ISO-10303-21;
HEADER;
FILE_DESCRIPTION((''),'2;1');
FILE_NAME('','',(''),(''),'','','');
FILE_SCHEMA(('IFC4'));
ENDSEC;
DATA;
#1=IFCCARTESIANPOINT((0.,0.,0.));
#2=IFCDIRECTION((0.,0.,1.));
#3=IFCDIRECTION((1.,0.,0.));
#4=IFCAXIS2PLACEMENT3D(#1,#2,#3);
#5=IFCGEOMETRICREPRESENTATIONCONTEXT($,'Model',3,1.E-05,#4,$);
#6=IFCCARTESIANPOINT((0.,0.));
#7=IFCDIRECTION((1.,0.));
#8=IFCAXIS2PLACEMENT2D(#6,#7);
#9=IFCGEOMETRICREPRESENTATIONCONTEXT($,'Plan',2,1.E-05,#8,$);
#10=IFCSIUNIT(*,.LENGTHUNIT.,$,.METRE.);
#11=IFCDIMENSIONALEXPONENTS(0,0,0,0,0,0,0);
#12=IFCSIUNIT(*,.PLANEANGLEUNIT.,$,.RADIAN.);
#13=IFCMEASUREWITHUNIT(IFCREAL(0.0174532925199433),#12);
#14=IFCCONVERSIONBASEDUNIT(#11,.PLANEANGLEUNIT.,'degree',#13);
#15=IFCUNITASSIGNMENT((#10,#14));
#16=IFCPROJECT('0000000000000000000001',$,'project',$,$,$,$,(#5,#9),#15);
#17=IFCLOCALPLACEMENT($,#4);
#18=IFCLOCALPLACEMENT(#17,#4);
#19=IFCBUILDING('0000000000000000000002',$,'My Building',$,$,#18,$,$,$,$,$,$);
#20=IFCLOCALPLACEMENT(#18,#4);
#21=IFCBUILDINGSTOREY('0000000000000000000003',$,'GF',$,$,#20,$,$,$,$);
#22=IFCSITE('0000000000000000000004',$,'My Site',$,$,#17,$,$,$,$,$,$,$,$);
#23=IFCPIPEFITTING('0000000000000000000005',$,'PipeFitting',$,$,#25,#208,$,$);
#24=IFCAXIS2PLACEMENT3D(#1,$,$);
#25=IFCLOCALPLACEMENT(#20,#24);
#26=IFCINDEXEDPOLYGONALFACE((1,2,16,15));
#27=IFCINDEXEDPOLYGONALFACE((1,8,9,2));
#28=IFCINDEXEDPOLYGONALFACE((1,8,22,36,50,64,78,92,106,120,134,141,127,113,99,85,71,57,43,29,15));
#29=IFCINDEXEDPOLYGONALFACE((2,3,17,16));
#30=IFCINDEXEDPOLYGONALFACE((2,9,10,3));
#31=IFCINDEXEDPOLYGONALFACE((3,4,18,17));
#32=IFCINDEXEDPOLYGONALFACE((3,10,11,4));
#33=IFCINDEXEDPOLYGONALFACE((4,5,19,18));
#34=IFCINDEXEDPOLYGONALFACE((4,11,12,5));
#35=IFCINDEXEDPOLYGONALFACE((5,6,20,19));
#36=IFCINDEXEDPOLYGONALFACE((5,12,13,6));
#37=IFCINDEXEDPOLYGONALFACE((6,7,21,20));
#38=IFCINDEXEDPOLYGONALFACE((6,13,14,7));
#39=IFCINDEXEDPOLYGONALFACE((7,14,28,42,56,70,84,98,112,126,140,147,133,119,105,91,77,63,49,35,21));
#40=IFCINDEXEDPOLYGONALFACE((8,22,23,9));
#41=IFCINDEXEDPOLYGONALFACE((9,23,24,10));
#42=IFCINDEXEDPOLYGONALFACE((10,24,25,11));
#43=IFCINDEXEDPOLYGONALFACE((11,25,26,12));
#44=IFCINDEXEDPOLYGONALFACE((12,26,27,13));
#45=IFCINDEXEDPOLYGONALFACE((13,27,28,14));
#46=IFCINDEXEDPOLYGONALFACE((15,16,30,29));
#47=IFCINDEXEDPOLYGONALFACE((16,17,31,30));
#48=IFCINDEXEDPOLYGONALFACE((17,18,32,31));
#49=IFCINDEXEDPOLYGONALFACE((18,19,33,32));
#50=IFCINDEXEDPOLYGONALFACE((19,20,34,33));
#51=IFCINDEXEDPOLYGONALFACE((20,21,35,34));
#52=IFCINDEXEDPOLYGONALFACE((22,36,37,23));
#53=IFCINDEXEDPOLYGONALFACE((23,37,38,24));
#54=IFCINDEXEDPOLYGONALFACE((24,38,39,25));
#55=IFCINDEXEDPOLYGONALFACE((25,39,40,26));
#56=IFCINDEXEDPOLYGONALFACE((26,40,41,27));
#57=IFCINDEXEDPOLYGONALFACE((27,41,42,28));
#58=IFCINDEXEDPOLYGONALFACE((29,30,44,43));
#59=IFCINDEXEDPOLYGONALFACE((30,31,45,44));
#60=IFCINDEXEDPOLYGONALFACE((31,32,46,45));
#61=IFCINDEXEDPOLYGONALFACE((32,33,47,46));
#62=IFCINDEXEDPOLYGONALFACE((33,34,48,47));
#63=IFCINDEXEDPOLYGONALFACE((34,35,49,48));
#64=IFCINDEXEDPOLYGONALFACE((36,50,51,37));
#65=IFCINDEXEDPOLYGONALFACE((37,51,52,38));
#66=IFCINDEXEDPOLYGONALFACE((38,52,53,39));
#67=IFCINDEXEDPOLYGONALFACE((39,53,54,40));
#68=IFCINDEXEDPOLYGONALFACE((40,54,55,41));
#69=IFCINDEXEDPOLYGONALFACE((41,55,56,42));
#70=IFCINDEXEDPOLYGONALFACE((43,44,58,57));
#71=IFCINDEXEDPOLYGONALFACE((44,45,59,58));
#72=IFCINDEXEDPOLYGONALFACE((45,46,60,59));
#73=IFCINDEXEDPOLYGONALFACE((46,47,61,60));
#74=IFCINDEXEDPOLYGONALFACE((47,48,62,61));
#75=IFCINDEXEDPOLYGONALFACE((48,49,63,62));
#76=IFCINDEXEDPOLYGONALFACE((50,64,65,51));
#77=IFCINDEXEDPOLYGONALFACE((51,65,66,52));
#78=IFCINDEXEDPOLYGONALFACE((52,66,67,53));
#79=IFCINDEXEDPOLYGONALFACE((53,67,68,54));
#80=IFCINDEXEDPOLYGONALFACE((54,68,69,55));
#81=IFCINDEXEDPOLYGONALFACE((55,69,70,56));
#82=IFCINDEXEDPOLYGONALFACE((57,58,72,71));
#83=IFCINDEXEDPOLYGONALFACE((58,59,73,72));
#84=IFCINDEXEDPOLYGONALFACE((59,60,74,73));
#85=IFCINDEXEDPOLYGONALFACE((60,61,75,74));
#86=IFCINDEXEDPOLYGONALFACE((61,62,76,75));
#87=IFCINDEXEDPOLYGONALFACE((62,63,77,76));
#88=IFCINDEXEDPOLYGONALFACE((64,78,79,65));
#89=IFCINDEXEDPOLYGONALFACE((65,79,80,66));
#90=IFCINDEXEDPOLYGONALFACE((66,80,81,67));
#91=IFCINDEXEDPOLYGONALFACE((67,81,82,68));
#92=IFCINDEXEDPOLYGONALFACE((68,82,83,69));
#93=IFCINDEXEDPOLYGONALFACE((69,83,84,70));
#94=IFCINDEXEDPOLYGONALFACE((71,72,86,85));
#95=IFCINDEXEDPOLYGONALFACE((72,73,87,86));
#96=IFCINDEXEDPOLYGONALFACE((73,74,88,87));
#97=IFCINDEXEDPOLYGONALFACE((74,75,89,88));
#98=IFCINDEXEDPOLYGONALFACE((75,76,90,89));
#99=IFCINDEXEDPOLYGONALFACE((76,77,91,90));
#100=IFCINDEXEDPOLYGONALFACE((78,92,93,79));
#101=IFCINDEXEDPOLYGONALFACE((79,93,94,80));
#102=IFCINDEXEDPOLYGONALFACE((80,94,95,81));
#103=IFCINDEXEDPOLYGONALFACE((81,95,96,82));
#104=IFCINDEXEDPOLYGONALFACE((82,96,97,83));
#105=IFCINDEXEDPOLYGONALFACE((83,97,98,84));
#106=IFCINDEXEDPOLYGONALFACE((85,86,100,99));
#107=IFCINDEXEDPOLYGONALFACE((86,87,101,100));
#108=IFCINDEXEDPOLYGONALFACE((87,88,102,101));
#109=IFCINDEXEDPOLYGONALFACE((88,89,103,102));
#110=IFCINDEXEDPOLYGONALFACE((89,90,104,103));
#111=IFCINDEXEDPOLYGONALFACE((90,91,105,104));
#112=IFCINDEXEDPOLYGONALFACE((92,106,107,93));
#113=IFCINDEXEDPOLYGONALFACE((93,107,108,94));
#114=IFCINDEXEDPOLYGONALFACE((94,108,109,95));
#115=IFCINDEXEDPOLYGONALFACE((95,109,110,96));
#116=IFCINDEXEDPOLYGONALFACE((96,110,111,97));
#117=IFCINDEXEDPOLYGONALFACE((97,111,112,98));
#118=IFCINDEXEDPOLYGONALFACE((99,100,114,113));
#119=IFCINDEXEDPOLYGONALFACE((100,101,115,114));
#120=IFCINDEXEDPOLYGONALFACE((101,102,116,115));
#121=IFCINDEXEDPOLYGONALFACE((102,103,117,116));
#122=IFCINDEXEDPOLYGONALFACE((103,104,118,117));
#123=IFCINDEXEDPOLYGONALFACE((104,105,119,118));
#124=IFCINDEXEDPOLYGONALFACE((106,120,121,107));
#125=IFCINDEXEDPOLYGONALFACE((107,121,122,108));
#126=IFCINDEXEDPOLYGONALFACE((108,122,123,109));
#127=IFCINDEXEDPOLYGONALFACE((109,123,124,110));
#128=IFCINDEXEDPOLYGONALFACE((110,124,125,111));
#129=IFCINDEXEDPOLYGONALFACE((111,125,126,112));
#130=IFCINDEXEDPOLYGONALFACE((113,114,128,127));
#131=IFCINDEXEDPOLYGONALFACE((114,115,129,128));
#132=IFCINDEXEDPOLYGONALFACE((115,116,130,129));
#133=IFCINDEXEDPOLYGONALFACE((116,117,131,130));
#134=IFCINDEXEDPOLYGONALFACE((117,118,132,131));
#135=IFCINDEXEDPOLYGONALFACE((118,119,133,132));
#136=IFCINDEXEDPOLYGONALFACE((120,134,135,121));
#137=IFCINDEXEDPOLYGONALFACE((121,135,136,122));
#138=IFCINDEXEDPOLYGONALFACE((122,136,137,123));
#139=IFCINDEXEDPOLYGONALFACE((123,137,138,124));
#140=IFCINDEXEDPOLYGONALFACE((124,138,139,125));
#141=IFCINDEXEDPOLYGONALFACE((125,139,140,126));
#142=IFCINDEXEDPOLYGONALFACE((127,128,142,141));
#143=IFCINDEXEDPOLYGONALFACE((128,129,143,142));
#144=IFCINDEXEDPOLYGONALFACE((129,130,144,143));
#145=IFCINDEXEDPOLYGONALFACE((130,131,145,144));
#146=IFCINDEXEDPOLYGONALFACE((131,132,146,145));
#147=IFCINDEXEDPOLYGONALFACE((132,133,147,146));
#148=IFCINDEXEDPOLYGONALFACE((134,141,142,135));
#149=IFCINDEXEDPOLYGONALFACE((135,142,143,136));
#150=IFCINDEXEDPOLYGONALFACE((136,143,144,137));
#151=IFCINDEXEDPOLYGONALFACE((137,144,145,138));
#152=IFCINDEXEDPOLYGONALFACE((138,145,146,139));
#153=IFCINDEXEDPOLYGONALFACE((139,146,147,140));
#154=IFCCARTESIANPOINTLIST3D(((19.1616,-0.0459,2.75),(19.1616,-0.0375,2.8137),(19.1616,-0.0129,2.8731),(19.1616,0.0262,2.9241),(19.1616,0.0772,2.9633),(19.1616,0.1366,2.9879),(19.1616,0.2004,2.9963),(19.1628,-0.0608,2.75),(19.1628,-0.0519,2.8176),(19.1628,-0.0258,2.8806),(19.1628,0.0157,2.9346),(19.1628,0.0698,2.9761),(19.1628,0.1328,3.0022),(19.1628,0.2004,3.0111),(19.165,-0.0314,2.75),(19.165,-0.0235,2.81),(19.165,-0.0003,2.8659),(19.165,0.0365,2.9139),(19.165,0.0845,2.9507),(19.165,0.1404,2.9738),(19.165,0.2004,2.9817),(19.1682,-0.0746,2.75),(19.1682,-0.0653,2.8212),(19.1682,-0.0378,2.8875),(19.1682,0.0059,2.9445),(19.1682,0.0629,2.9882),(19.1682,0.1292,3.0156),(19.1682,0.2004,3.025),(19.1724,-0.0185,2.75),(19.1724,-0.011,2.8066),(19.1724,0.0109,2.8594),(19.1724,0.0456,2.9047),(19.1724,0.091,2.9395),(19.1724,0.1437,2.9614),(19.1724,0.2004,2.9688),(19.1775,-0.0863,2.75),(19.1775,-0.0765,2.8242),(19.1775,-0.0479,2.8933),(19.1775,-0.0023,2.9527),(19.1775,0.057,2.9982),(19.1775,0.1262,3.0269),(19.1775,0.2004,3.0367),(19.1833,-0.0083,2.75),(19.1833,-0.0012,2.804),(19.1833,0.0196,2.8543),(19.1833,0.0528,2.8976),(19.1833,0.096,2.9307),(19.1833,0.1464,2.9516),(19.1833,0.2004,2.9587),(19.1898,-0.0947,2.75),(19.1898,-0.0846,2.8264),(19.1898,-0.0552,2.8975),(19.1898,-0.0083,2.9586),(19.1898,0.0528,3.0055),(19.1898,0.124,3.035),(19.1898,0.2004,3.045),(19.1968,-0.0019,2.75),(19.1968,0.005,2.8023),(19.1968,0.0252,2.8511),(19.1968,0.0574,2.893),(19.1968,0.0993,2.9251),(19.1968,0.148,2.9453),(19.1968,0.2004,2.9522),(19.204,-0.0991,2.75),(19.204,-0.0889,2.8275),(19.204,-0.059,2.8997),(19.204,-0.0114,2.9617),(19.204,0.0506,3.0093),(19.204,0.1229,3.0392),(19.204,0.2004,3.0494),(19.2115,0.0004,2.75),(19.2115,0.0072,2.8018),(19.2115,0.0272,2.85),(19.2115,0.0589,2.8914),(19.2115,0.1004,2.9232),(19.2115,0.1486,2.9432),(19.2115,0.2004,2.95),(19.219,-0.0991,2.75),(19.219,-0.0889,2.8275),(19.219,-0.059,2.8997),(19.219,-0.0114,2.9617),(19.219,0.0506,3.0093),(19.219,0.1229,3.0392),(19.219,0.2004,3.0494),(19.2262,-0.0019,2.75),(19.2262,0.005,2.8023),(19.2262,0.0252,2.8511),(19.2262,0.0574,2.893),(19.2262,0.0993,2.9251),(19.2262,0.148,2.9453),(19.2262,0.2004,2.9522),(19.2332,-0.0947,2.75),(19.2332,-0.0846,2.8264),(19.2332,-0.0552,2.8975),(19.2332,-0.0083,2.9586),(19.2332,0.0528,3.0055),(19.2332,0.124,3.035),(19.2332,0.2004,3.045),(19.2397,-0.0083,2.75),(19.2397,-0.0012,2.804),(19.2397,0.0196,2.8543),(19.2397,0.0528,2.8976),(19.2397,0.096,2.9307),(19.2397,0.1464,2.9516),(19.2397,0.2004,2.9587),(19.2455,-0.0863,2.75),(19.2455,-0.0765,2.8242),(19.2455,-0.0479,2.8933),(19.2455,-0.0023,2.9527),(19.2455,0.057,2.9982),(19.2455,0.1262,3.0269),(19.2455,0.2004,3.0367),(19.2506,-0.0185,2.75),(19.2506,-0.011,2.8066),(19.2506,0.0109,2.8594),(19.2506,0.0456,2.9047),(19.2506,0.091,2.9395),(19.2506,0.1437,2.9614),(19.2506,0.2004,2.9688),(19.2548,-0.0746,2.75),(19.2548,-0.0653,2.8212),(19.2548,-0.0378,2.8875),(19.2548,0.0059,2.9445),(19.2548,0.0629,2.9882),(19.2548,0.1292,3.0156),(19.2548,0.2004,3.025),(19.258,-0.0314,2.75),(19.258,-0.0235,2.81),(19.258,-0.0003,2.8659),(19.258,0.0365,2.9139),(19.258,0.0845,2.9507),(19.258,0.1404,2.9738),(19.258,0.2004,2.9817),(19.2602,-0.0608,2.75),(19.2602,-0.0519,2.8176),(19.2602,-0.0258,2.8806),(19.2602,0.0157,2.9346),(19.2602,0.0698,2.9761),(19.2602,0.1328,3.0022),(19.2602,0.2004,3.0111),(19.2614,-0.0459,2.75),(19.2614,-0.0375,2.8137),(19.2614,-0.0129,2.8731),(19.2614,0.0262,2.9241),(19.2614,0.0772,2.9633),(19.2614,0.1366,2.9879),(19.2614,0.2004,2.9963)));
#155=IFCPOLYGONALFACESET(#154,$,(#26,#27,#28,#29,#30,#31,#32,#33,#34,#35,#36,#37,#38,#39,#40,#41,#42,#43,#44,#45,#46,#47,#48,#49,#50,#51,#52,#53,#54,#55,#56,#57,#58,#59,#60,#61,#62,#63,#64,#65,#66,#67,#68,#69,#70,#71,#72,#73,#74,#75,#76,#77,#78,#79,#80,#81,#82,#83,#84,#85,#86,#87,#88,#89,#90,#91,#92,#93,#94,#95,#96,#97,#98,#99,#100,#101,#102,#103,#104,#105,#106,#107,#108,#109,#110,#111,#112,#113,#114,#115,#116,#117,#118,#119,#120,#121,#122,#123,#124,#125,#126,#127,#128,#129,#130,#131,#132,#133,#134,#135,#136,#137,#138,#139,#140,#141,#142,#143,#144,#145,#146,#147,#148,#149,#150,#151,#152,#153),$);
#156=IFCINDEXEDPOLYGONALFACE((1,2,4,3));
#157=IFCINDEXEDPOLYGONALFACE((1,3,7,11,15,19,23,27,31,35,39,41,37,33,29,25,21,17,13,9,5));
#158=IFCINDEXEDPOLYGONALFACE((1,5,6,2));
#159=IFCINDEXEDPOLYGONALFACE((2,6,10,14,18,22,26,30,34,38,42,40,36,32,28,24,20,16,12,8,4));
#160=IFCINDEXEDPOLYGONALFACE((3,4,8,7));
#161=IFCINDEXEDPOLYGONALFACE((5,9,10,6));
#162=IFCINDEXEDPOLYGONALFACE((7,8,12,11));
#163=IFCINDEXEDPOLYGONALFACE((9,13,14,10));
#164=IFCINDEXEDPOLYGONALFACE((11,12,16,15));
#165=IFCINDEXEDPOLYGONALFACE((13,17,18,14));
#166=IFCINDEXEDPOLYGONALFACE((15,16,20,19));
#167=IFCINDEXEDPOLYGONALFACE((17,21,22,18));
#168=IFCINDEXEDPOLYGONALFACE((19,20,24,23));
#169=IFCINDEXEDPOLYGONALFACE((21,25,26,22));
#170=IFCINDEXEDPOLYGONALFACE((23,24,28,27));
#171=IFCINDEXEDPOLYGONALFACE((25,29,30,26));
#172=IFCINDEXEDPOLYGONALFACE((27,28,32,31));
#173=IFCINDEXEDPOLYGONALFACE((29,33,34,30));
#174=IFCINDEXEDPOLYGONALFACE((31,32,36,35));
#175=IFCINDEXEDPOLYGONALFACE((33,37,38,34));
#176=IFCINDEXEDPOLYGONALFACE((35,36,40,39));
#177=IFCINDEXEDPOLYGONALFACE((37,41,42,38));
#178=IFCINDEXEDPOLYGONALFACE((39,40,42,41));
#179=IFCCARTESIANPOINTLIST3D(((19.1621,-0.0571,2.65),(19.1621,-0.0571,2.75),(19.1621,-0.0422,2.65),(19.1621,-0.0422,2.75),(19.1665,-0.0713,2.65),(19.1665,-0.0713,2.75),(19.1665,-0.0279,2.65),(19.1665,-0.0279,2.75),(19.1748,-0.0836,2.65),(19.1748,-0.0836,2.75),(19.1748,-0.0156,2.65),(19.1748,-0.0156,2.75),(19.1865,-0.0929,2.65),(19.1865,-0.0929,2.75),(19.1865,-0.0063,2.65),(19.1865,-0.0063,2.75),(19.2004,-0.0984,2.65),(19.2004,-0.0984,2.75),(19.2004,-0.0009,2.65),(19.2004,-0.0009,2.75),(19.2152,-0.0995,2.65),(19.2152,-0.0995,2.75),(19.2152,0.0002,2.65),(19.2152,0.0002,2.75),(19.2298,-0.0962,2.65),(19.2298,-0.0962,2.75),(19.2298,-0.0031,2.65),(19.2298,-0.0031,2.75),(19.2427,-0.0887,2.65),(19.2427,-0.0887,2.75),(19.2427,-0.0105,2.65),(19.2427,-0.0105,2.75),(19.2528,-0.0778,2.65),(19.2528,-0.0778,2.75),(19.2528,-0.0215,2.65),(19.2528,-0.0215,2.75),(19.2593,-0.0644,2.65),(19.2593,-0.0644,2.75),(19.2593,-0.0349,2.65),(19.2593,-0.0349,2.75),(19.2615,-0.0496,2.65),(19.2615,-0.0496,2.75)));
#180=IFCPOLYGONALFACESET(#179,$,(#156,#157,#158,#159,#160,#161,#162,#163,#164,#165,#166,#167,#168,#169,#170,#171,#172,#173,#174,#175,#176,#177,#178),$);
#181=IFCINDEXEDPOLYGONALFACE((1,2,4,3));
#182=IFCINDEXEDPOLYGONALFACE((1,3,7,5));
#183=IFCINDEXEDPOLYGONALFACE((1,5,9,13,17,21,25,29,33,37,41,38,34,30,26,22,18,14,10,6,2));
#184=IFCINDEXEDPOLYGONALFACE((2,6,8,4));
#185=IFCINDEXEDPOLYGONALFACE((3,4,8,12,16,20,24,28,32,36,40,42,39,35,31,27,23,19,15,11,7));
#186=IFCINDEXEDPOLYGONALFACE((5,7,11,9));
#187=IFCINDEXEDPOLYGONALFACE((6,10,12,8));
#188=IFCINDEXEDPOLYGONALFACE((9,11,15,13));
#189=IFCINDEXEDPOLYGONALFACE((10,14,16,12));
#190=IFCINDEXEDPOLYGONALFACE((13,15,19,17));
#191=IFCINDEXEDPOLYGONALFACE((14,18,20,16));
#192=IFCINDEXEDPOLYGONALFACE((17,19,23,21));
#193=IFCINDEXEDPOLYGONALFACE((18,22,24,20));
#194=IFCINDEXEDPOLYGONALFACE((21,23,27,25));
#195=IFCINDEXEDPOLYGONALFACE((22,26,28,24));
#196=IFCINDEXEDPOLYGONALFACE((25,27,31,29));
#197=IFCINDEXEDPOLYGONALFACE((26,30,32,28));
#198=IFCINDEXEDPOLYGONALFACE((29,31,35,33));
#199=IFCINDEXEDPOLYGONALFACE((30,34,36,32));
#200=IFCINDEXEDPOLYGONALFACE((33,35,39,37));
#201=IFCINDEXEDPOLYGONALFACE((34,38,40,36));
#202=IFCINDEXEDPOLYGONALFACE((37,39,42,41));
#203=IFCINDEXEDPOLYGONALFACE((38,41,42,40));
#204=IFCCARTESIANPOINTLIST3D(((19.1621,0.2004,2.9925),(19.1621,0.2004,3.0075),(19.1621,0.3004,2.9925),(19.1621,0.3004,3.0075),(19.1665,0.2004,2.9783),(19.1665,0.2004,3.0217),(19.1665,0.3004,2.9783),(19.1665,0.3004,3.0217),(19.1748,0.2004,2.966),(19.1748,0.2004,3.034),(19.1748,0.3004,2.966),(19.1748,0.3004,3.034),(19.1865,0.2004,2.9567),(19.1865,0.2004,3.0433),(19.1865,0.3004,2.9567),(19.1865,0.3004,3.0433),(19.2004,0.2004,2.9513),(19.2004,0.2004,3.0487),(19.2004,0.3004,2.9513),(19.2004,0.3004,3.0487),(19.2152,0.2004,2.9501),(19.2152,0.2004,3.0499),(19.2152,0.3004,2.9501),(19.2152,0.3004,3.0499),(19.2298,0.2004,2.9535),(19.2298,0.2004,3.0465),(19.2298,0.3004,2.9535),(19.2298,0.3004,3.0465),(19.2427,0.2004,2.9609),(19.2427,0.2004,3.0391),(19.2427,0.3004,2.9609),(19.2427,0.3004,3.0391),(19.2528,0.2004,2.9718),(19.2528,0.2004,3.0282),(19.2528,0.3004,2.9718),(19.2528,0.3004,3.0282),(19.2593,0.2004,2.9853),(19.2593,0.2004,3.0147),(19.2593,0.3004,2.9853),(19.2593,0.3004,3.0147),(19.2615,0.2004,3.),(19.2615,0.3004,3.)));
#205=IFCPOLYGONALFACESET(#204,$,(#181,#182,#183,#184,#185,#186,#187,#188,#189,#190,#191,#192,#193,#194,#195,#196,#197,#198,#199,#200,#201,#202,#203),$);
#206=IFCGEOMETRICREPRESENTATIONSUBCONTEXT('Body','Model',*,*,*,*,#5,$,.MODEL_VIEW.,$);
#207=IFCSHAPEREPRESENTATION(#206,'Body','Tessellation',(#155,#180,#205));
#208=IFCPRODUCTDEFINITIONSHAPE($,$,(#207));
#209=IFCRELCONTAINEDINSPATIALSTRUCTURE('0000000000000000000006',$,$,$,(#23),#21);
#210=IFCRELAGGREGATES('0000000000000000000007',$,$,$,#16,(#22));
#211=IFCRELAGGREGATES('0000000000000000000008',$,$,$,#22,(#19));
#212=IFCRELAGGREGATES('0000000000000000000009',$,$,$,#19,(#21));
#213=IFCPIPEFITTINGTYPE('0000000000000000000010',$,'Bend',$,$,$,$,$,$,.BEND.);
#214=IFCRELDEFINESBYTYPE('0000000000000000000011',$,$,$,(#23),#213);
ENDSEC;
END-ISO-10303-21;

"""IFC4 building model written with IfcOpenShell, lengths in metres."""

from ifc_helpers import new_model, entity, si_unit, converted_unit, frame, origin_with_axes, origin_2d_with_axis, place, context, subcontext, project, spatial, circle, extrude, source, transform, mapped, type_object, type_shapes, element, save


model = new_model("IFC4")

# Units and contexts
model_context = context("Model", 3, precision=1e-05, world=origin_with_axes())
plan_context = context("Plan", 2, precision=1e-05, world=origin_2d_with_axis())
body_context_1 = subcontext(model_context, "Body", "Model", "MODEL_VIEW")
ifc_project = project(units=[si_unit("LENGTHUNIT", "METRE"), converted_unit("PLANEANGLEUNIT", "degree", entity("IfcReal", 0.0174532925199433), si_unit("PLANEANGLEUNIT", "RADIAN"), dimensions=[0, 0, 0, 0, 0, 0, 0])], contexts=[model_context, plan_context])

# Site, building, storey
site_placement = place(None, origin_with_axes())
site = spatial("IfcSite", under=ifc_project, at=site_placement, Name="My Site")
building_placement = place(site_placement, origin_with_axes())
building = spatial("IfcBuilding", under=site, at=building_placement, Name="My Building")
storey_placement = place(building_placement, origin_with_axes())
storey = spatial("IfcBuildingStorey", under=building, at=storey_placement, Name="GF")

# Pipe fitting
pipe_fitting_type = type_object("IfcPipeFittingType", Name="Bend", PredefinedType="BEND")
shared_shape_1 = source(origin_with_axes(), body_context_1, "Body", "SolidModel", [
    entity("IfcSweptDiskSolid", entity("IfcIndexedPolyCurve", entity("IfcCartesianPointList3D", [[0.0, 0.0, -0.1], [0.0, -0.0732, -0.2768], [0.0, -0.25, -0.35]]), [entity("IfcArcIndex", [1, 2, 3])]), 0.05),
    extrude(circle(Radius=0.05), origin_with_axes(), (0.0, 0.0, -1.0), 0.1),
    extrude(circle(Radius=0.05), frame((0.0, -0.25, -0.35), z_axis=(0.0, -1.0, 0.0), x_axis=(1.0, 0.0, 0.0)), (0.0, 0.0, 1.0), 0.1),
])
type_shapes(pipe_fitting_type, [shared_shape_1])
for number, where, z_axis, x_axis, name in (
    (1, (19.2115, -0.0496, 2.65), (0.0, 0.0, -1.0), (1.0, 0.0, 0.0), "PipeFitting"),
):
    element("IfcPipeFitting", number, at=place(storey_placement, frame(where, z_axis=z_axis, x_axis=x_axis)), inside=storey, type_object=pipe_fitting_type, Name=name, context=body_context_1, shape_type="MappedRepresentation", body=[
        mapped(shared_shape_1, transform((0.0, 0.0, 0.0), x_axis=(1.0, 0.0, 0.0), y_axis=(0.0, 1.0, 0.0), z_axis=(0.0, 0.0, 1.0), scale=1.0)),
    ])

save(model, "model.ifc")
